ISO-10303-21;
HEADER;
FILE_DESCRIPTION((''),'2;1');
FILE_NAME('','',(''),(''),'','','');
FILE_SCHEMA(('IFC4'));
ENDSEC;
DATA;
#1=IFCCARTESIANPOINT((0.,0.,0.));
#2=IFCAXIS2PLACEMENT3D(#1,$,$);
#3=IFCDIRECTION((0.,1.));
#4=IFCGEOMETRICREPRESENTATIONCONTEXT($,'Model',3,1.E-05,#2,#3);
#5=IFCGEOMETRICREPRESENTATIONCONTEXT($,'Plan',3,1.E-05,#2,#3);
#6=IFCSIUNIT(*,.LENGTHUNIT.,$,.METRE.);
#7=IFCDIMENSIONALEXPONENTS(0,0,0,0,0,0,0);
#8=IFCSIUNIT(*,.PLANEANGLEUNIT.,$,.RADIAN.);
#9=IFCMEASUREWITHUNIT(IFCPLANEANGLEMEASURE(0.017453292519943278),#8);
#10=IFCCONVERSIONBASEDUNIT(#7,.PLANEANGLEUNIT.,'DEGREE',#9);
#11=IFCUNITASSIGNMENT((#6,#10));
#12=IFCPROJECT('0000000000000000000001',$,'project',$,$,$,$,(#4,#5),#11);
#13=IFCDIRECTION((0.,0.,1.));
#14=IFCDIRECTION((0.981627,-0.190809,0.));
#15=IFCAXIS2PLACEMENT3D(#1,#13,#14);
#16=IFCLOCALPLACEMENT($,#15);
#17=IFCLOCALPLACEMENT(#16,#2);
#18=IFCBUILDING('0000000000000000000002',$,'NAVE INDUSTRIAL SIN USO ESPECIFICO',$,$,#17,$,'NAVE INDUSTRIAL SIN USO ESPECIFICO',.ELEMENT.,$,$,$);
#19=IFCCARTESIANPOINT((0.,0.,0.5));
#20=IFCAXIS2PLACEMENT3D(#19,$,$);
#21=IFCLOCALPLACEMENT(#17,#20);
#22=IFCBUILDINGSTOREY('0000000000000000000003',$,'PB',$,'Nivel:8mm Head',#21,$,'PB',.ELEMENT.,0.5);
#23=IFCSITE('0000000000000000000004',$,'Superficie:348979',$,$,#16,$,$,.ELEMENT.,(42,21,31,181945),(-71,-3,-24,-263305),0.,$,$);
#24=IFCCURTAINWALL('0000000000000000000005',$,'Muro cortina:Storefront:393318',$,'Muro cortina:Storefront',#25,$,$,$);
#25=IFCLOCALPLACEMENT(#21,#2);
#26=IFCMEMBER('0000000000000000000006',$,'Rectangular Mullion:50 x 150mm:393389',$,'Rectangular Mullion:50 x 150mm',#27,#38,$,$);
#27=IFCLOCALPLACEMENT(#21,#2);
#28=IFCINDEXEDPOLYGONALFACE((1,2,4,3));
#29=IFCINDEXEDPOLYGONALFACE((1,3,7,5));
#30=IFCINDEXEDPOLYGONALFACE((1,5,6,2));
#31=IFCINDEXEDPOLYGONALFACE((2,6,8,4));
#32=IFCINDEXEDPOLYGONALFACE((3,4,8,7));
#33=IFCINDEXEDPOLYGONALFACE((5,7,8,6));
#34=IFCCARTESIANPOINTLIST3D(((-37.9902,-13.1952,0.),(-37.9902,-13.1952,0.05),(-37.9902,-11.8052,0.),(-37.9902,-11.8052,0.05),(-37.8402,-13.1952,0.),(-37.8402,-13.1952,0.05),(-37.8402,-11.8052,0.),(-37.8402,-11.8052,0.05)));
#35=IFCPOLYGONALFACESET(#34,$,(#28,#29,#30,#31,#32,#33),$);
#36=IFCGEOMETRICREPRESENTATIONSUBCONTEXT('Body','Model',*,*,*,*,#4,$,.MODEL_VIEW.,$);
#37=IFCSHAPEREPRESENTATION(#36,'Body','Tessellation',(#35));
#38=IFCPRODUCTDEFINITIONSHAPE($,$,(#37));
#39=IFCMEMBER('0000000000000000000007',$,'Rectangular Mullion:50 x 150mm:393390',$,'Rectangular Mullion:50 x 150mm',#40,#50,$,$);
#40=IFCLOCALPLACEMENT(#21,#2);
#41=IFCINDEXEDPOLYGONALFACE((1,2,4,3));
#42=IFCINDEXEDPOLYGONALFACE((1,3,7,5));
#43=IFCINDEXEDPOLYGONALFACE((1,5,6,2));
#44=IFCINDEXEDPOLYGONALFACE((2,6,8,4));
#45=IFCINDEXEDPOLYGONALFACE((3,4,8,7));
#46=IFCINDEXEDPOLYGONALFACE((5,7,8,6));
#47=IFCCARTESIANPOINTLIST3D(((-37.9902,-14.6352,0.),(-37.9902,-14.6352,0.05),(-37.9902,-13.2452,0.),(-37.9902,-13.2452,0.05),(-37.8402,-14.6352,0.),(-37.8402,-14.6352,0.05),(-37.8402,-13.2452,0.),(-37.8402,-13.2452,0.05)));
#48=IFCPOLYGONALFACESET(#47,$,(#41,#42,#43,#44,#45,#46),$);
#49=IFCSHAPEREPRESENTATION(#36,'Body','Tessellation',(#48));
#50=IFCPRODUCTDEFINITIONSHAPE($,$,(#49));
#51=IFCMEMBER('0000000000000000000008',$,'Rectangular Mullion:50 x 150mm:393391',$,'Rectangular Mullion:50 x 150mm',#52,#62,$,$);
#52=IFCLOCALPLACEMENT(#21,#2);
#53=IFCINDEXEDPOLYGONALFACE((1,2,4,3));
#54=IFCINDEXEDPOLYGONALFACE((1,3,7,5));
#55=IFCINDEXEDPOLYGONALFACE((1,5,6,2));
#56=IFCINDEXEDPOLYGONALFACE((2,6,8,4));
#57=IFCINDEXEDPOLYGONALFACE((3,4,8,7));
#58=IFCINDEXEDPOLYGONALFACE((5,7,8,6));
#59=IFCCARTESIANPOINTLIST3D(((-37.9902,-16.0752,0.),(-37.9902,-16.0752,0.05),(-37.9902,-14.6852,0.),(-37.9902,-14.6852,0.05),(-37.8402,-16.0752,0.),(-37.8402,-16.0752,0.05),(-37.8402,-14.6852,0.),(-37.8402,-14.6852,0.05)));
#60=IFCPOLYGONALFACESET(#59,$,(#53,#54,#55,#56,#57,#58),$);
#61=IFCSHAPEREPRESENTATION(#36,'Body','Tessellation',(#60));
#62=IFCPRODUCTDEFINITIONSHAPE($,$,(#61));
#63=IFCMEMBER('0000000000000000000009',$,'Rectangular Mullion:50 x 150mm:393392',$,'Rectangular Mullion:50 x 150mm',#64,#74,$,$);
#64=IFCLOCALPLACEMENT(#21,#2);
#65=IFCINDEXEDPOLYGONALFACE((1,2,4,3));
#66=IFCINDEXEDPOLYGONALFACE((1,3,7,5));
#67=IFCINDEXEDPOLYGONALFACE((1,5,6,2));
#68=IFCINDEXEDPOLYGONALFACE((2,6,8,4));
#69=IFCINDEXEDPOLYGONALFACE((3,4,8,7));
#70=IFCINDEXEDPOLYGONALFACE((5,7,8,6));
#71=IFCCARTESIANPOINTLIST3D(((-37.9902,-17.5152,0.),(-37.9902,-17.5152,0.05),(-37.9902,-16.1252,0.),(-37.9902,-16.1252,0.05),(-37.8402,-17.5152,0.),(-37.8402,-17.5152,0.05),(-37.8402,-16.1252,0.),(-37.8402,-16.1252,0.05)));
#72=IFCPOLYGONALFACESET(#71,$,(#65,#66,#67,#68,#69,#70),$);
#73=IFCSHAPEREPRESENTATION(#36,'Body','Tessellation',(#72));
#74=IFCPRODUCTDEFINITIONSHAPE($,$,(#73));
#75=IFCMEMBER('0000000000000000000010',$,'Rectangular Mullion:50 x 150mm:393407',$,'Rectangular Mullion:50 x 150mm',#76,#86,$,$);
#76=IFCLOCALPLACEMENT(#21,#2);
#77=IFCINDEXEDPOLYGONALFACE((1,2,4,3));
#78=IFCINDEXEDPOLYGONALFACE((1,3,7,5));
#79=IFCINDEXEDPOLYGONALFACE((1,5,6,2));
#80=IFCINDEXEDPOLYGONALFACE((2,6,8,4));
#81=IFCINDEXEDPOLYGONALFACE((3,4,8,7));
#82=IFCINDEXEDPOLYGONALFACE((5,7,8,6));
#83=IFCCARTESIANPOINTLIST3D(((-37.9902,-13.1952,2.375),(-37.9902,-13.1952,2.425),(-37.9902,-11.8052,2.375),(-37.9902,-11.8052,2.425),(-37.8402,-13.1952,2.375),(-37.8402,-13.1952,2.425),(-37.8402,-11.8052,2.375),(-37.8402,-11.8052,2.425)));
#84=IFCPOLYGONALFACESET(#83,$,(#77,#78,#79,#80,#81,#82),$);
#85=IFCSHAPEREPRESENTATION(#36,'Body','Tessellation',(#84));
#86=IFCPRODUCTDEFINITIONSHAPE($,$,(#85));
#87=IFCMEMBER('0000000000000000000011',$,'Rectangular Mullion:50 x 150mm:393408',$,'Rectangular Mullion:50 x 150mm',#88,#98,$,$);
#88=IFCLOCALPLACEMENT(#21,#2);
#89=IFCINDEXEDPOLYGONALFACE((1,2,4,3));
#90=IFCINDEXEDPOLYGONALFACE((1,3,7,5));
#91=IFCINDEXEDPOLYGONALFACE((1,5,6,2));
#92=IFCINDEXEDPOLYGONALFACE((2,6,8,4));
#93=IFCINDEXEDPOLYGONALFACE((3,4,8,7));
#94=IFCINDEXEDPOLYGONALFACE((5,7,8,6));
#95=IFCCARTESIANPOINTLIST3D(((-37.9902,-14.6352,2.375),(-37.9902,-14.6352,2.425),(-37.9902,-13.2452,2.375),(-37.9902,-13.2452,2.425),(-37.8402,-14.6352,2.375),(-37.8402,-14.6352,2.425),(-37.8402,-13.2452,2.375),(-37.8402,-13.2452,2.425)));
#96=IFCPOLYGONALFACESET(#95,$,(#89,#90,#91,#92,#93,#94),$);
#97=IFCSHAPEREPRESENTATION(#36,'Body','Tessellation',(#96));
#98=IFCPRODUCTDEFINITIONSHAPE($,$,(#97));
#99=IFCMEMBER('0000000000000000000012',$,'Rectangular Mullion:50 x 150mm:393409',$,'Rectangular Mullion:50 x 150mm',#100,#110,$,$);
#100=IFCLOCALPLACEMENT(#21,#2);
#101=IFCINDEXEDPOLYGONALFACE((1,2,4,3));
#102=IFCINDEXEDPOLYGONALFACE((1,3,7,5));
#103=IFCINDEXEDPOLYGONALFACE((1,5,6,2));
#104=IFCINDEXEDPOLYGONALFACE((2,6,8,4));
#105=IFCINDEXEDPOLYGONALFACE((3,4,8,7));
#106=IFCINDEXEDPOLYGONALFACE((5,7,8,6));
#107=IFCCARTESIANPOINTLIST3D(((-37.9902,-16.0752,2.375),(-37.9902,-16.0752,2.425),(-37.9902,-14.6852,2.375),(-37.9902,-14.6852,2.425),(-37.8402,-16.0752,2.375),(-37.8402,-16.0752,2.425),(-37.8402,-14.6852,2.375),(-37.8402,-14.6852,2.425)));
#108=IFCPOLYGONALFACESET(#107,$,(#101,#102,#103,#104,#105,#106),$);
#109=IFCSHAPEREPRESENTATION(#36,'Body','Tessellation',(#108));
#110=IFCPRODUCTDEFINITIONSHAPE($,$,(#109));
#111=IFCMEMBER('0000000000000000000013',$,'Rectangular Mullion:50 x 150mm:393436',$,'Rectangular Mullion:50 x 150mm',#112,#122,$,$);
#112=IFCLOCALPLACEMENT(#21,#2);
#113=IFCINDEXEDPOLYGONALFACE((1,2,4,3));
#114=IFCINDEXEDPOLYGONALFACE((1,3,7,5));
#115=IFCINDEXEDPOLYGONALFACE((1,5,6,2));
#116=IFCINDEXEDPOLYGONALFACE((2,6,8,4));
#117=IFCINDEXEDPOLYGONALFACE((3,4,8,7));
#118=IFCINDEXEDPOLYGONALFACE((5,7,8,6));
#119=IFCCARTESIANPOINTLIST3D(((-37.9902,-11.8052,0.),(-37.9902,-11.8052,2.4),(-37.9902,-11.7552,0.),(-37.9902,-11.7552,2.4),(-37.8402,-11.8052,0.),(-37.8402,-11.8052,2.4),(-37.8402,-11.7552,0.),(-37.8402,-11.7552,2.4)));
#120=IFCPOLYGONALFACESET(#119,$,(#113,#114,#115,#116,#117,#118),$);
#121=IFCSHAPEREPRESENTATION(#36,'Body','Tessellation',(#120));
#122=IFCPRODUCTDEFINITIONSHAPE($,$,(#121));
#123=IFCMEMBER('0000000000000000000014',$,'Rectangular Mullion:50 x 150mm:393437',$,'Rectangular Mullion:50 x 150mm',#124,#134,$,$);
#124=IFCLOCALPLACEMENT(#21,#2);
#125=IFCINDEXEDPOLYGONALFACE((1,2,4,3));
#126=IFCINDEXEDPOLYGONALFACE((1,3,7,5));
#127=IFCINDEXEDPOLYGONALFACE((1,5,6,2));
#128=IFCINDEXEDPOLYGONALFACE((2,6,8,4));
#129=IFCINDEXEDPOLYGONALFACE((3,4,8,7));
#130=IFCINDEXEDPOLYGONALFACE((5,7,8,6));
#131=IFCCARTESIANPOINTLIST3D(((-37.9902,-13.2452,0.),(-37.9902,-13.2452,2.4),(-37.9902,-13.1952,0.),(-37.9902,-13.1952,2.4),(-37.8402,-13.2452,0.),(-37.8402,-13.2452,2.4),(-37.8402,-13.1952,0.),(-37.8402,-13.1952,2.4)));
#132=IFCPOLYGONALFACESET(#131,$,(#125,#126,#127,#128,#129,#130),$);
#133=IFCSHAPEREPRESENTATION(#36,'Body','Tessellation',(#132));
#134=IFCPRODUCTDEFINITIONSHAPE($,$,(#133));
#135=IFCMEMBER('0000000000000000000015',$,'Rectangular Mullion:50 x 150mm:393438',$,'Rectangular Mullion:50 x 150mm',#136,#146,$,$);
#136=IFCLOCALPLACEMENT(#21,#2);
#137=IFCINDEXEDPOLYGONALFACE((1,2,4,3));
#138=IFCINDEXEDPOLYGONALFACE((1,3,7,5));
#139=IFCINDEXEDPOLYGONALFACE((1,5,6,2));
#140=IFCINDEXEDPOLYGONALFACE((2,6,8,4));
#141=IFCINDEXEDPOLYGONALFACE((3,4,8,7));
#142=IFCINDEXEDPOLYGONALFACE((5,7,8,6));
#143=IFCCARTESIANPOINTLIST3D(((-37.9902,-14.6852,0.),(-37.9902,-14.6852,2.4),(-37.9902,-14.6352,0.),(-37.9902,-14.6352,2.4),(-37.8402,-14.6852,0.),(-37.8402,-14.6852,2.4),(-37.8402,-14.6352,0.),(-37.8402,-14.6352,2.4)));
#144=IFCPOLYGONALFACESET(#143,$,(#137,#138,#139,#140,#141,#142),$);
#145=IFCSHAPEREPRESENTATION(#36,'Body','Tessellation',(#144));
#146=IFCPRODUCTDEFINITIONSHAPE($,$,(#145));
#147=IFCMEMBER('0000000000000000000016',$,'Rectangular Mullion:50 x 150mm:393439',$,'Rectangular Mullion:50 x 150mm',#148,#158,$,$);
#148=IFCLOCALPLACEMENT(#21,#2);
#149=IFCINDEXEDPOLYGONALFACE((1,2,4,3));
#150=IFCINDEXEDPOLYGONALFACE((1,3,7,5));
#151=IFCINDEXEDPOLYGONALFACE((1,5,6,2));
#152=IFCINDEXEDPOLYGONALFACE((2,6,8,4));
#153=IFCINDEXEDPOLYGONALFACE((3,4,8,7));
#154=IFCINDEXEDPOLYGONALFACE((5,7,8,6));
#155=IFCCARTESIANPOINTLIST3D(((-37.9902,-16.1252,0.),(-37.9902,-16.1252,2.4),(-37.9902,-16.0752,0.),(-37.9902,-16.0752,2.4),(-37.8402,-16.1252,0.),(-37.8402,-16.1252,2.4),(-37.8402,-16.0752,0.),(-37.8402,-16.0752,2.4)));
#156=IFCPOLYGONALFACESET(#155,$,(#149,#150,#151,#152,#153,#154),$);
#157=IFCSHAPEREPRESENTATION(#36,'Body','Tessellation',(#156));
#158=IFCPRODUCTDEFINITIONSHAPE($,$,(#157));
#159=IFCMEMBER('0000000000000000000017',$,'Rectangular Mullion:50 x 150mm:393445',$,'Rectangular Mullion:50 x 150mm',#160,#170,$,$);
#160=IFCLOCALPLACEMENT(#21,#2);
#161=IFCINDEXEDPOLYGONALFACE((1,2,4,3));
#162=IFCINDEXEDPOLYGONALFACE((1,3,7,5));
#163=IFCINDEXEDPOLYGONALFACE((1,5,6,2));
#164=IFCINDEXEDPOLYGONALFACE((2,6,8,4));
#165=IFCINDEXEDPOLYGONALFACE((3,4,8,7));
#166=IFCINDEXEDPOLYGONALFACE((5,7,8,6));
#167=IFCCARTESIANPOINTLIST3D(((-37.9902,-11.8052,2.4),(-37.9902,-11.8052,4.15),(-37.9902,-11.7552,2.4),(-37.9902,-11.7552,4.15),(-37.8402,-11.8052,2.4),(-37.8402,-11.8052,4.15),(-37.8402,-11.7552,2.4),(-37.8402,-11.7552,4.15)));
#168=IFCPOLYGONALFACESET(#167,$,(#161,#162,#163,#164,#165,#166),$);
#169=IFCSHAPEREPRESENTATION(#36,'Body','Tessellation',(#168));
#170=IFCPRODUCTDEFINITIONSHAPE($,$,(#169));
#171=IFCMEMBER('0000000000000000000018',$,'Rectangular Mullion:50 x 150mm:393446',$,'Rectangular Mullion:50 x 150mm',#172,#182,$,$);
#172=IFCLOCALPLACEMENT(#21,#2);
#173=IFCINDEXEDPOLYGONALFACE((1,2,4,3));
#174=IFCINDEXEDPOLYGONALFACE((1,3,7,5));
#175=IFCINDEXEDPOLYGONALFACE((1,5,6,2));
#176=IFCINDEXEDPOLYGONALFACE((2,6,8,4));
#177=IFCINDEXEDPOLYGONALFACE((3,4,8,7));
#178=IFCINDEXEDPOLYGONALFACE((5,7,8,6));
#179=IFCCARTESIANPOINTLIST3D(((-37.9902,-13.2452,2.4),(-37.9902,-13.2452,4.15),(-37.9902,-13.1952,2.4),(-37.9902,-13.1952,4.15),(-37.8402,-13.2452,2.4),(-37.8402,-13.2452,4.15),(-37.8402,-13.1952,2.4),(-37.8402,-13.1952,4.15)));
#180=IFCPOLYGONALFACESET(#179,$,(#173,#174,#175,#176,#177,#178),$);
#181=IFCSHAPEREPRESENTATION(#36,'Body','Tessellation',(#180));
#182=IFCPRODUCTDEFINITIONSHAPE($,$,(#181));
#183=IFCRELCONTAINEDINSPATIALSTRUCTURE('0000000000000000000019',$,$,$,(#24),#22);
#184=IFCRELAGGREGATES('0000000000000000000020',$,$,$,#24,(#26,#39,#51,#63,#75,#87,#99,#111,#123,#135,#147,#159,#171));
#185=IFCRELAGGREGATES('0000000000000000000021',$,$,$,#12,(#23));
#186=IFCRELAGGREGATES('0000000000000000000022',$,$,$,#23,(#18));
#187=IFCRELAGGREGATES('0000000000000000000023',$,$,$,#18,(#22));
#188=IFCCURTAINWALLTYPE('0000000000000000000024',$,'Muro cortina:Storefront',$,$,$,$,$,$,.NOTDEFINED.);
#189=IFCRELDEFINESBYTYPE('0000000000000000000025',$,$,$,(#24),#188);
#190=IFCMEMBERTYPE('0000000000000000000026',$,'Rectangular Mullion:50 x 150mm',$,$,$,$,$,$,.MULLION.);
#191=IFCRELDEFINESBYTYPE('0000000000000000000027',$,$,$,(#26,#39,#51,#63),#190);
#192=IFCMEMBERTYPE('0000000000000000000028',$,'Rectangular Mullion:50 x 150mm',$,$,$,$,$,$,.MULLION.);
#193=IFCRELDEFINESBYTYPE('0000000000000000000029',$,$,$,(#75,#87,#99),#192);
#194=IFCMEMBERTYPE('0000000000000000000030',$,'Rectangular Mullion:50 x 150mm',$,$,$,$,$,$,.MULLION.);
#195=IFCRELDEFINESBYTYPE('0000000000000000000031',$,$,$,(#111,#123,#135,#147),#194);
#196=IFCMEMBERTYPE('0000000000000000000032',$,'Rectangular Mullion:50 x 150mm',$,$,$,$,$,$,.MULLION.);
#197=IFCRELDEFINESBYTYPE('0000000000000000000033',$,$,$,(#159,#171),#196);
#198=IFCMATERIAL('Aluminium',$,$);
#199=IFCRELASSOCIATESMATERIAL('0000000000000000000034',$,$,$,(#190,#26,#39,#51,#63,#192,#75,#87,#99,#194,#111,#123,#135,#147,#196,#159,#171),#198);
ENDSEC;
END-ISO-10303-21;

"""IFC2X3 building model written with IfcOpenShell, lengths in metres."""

from ifc_helpers import new_model, entity, si_unit, converted_unit, direction, frame, origin, origin_2d_with_axis, place, context, subcontext, project, spatial, rectangle, extrude, source, transform, mapped, material, type_object, type_shapes, element, aggregate, save


model = new_model("IFC2X3")

# Units and contexts
model_context = context("Model", 3, precision=1e-05, world=origin(), true_north=direction((0.0, 1.0)))
plan_context = context("Plan", 3, precision=1e-05, world=origin(), true_north=direction((0.0, 1.0)))
body_context = subcontext(model_context, "Body", "Model", "MODEL_VIEW")
ifc_project = project(units=[si_unit("LENGTHUNIT", "METRE"), converted_unit("PLANEANGLEUNIT", "DEGREE", entity("IfcPlaneAngleMeasure", 0.017453292519943278), si_unit("PLANEANGLEUNIT", "RADIAN"), dimensions=[0, 0, 0, 0, 0, 0, 0])], contexts=[model_context, plan_context])

# Site, building, storey
site_placement = place(None, frame((0.0, 0.0, 0.0), z_axis=(0.0, 0.0, 1.0), x_axis=(0.981627, -0.190809, 0.0)))
site = spatial("IfcSite", under=ifc_project, at=site_placement, Name="Superficie:348979", CompositionType="ELEMENT", RefLatitude=(42, 21, 31, 181945), RefLongitude=(-71, -3, -24, -263305), RefElevation=0.0)
building_placement = place(site_placement, origin())
building = spatial("IfcBuilding", under=site, at=building_placement, Name="NAVE INDUSTRIAL SIN USO ESPECIFICO", LongName="NAVE INDUSTRIAL SIN USO ESPECIFICO", CompositionType="ELEMENT")
storey_placement = place(building_placement, frame((0.0, 0.0, 0.5)))
storey = spatial("IfcBuildingStorey", under=building, at=storey_placement, Name="PB", ObjectType="Nivel:8mm Head", LongName="PB", CompositionType="ELEMENT", Elevation=0.5)

# Curtain wall, members
curtain_wall_type = type_object("IfcCurtainWallType", Name="Muro cortina:Storefront", PredefinedType="NOTDEFINED")
curtain_wall_placement = place(storey_placement, frame((0.0, 0.0, -0.5)))
curtain_wall = element("IfcCurtainWall", 1, at=curtain_wall_placement, inside=storey, type_object=curtain_wall_type, Name="Muro cortina:Storefront:393318", ObjectType="Muro cortina:Storefront")
ifc_material_1 = material(Name="Aluminium")
member_type_1 = type_object("IfcMemberType", Name="Rectangular Mullion:50 x 150mm", PredefinedType="MULLION", material=ifc_material_1)
shared_shape_1 = source(origin(), body_context, "Body", "SweptSolid", [
    extrude(rectangle(XDim=0.05, YDim=0.15, at=origin_2d_with_axis()), frame((-0.025, 0.0, -1.39), z_axis=(0.0, 0.0, 1.0), x_axis=(-1.0, 0.0, 0.0)), (0.0, 0.0, 1.0), 1.39),
])
type_shapes(member_type_1, [shared_shape_1])
member_1_placement = place(curtain_wall_placement, frame((-37.9152, -11.8052, 0.5), z_axis=(0.0, 1.0, 0.0), x_axis=(0.0, 0.0, -1.0)))
member_1 = element("IfcMember", 2, at=member_1_placement, type_object=member_type_1, material=ifc_material_1, Name="Rectangular Mullion:50 x 150mm:393389", ObjectType="Rectangular Mullion:50 x 150mm", context=body_context, shape_type="MappedRepresentation", body=[
    mapped(shared_shape_1, transform((0.0, 0.0, 0.0), scale=1.0)),
])
member_2_placement = place(curtain_wall_placement, frame((-37.9152, -13.2452, 0.5), z_axis=(0.0, 1.0, 0.0), x_axis=(0.0, 0.0, -1.0)))
member_2 = element("IfcMember", 3, at=member_2_placement, type_object=member_type_1, material=ifc_material_1, Name="Rectangular Mullion:50 x 150mm:393390", ObjectType="Rectangular Mullion:50 x 150mm", context=body_context, shape_type="MappedRepresentation", body=[
    mapped(shared_shape_1, transform((0.0, 0.0, 0.0), scale=1.0)),
])
member_3_placement = place(curtain_wall_placement, frame((-37.9152, -14.6852, 0.5), z_axis=(0.0, 1.0, 0.0), x_axis=(0.0, 0.0, -1.0)))
member_3 = element("IfcMember", 4, at=member_3_placement, type_object=member_type_1, material=ifc_material_1, Name="Rectangular Mullion:50 x 150mm:393391", ObjectType="Rectangular Mullion:50 x 150mm", context=body_context, shape_type="MappedRepresentation", body=[
    mapped(shared_shape_1, transform((0.0, 0.0, 0.0), scale=1.0)),
])
member_4_placement = place(curtain_wall_placement, frame((-37.9152, -16.1252, 0.5), z_axis=(0.0, 1.0, 0.0), x_axis=(0.0, 0.0, -1.0)))
member_4 = element("IfcMember", 5, at=member_4_placement, type_object=member_type_1, material=ifc_material_1, Name="Rectangular Mullion:50 x 150mm:393392", ObjectType="Rectangular Mullion:50 x 150mm", context=body_context, shape_type="MappedRepresentation", body=[
    mapped(shared_shape_1, transform((0.0, 0.0, 0.0), scale=1.0)),
])
member_type_2 = type_object("IfcMemberType", Name="Rectangular Mullion:50 x 150mm", PredefinedType="MULLION", material=ifc_material_1)
shared_shape_2 = source(origin(), body_context, "Body", "SweptSolid", [
    extrude(rectangle(XDim=0.05, YDim=0.15, at=origin_2d_with_axis()), frame((0.0, 0.0, -1.39), z_axis=(0.0, 0.0, 1.0), x_axis=(-1.0, 0.0, 0.0)), (0.0, 0.0, 1.0), 1.39),
])
type_shapes(member_type_2, [shared_shape_2])
member_5_placement = place(curtain_wall_placement, frame((-37.9152, -13.1952, 2.9), z_axis=(0.0, -1.0, 0.0), x_axis=(0.0, 0.0, 1.0)))
member_5 = element("IfcMember", 6, at=member_5_placement, type_object=member_type_2, material=ifc_material_1, Name="Rectangular Mullion:50 x 150mm:393407", ObjectType="Rectangular Mullion:50 x 150mm", context=body_context, shape_type="MappedRepresentation", body=[
    mapped(shared_shape_2, transform((0.0, 0.0, 0.0), scale=1.0)),
])
member_6_placement = place(curtain_wall_placement, frame((-37.9152, -14.6352, 2.9), z_axis=(0.0, -1.0, 0.0), x_axis=(0.0, 0.0, 1.0)))
member_6 = element("IfcMember", 7, at=member_6_placement, type_object=member_type_2, material=ifc_material_1, Name="Rectangular Mullion:50 x 150mm:393408", ObjectType="Rectangular Mullion:50 x 150mm", context=body_context, shape_type="MappedRepresentation", body=[
    mapped(shared_shape_2, transform((0.0, 0.0, 0.0), scale=1.0)),
])
member_7_placement = place(curtain_wall_placement, frame((-37.9152, -16.0752, 2.9), z_axis=(0.0, -1.0, 0.0), x_axis=(0.0, 0.0, 1.0)))
member_7 = element("IfcMember", 8, at=member_7_placement, type_object=member_type_2, material=ifc_material_1, Name="Rectangular Mullion:50 x 150mm:393409", ObjectType="Rectangular Mullion:50 x 150mm", context=body_context, shape_type="MappedRepresentation", body=[
    mapped(shared_shape_2, transform((0.0, 0.0, 0.0), scale=1.0)),
])
member_type_3 = type_object("IfcMemberType", Name="Rectangular Mullion:50 x 150mm", PredefinedType="MULLION", material=ifc_material_1)
shared_shape_3 = source(origin(), body_context, "Body", "SweptSolid", [
    extrude(rectangle(XDim=0.05, YDim=0.15, at=origin_2d_with_axis()), frame((0.0, 0.0, -2.4), z_axis=(0.0, 0.0, 1.0), x_axis=(-1.0, 0.0, 0.0)), (0.0, 0.0, 1.0), 2.4),
])
type_shapes(member_type_3, [shared_shape_3])
member_8_placement = place(curtain_wall_placement, frame((-37.9152, -11.7802, 0.5), z_axis=(0.0, 0.0, -1.0), x_axis=(0.0, -1.0, 0.0)))
member_8 = element("IfcMember", 9, at=member_8_placement, type_object=member_type_3, material=ifc_material_1, Name="Rectangular Mullion:50 x 150mm:393436", ObjectType="Rectangular Mullion:50 x 150mm", context=body_context, shape_type="MappedRepresentation", body=[
    mapped(shared_shape_3, transform((0.0, 0.0, 0.0), scale=1.0)),
])
member_9_placement = place(curtain_wall_placement, frame((-37.9152, -13.2202, 0.5), z_axis=(0.0, 0.0, -1.0), x_axis=(0.0, -1.0, 0.0)))
member_9 = element("IfcMember", 10, at=member_9_placement, type_object=member_type_3, material=ifc_material_1, Name="Rectangular Mullion:50 x 150mm:393437", ObjectType="Rectangular Mullion:50 x 150mm", context=body_context, shape_type="MappedRepresentation", body=[
    mapped(shared_shape_3, transform((0.0, 0.0, 0.0), scale=1.0)),
])
member_10_placement = place(curtain_wall_placement, frame((-37.9152, -14.6602, 0.5), z_axis=(0.0, 0.0, -1.0), x_axis=(0.0, -1.0, 0.0)))
member_10 = element("IfcMember", 11, at=member_10_placement, type_object=member_type_3, material=ifc_material_1, Name="Rectangular Mullion:50 x 150mm:393438", ObjectType="Rectangular Mullion:50 x 150mm", context=body_context, shape_type="MappedRepresentation", body=[
    mapped(shared_shape_3, transform((0.0, 0.0, 0.0), scale=1.0)),
])
member_11_placement = place(curtain_wall_placement, frame((-37.9152, -16.1002, 0.5), z_axis=(0.0, 0.0, -1.0), x_axis=(0.0, -1.0, 0.0)))
member_11 = element("IfcMember", 12, at=member_11_placement, type_object=member_type_3, material=ifc_material_1, Name="Rectangular Mullion:50 x 150mm:393439", ObjectType="Rectangular Mullion:50 x 150mm", context=body_context, shape_type="MappedRepresentation", body=[
    mapped(shared_shape_3, transform((0.0, 0.0, 0.0), scale=1.0)),
])
member_type_4 = type_object("IfcMemberType", Name="Rectangular Mullion:50 x 150mm", PredefinedType="MULLION", material=ifc_material_1)
shared_shape_4 = source(origin(), body_context, "Body", "SweptSolid", [
    extrude(rectangle(XDim=0.05, YDim=0.15, at=origin_2d_with_axis()), frame((0.0, 0.0, -1.75), z_axis=(0.0, 0.0, 1.0), x_axis=(-1.0, 0.0, 0.0)), (0.0, 0.0, 1.0), 1.75),
])
type_shapes(member_type_4, [shared_shape_4])
member_12_placement = place(curtain_wall_placement, frame((-37.9152, -11.7802, 2.9), z_axis=(0.0, 0.0, -1.0), x_axis=(0.0, -1.0, 0.0)))
member_12 = element("IfcMember", 13, at=member_12_placement, type_object=member_type_4, material=ifc_material_1, Name="Rectangular Mullion:50 x 150mm:393445", ObjectType="Rectangular Mullion:50 x 150mm", context=body_context, shape_type="MappedRepresentation", body=[
    mapped(shared_shape_4, transform((0.0, 0.0, 0.0), scale=1.0)),
])
member_13_placement = place(curtain_wall_placement, frame((-37.9152, -13.2202, 2.9), z_axis=(0.0, 0.0, -1.0), x_axis=(0.0, -1.0, 0.0)))
member_13 = element("IfcMember", 14, at=member_13_placement, type_object=member_type_4, material=ifc_material_1, Name="Rectangular Mullion:50 x 150mm:393446", ObjectType="Rectangular Mullion:50 x 150mm", context=body_context, shape_type="MappedRepresentation", body=[
    mapped(shared_shape_4, transform((0.0, 0.0, 0.0), scale=1.0)),
])
aggregate(curtain_wall, [member_1, member_2, member_3, member_4, member_5, member_6, member_7, member_8, member_9, member_10, member_11, member_12, member_13])

save(model, "model.ifc")
